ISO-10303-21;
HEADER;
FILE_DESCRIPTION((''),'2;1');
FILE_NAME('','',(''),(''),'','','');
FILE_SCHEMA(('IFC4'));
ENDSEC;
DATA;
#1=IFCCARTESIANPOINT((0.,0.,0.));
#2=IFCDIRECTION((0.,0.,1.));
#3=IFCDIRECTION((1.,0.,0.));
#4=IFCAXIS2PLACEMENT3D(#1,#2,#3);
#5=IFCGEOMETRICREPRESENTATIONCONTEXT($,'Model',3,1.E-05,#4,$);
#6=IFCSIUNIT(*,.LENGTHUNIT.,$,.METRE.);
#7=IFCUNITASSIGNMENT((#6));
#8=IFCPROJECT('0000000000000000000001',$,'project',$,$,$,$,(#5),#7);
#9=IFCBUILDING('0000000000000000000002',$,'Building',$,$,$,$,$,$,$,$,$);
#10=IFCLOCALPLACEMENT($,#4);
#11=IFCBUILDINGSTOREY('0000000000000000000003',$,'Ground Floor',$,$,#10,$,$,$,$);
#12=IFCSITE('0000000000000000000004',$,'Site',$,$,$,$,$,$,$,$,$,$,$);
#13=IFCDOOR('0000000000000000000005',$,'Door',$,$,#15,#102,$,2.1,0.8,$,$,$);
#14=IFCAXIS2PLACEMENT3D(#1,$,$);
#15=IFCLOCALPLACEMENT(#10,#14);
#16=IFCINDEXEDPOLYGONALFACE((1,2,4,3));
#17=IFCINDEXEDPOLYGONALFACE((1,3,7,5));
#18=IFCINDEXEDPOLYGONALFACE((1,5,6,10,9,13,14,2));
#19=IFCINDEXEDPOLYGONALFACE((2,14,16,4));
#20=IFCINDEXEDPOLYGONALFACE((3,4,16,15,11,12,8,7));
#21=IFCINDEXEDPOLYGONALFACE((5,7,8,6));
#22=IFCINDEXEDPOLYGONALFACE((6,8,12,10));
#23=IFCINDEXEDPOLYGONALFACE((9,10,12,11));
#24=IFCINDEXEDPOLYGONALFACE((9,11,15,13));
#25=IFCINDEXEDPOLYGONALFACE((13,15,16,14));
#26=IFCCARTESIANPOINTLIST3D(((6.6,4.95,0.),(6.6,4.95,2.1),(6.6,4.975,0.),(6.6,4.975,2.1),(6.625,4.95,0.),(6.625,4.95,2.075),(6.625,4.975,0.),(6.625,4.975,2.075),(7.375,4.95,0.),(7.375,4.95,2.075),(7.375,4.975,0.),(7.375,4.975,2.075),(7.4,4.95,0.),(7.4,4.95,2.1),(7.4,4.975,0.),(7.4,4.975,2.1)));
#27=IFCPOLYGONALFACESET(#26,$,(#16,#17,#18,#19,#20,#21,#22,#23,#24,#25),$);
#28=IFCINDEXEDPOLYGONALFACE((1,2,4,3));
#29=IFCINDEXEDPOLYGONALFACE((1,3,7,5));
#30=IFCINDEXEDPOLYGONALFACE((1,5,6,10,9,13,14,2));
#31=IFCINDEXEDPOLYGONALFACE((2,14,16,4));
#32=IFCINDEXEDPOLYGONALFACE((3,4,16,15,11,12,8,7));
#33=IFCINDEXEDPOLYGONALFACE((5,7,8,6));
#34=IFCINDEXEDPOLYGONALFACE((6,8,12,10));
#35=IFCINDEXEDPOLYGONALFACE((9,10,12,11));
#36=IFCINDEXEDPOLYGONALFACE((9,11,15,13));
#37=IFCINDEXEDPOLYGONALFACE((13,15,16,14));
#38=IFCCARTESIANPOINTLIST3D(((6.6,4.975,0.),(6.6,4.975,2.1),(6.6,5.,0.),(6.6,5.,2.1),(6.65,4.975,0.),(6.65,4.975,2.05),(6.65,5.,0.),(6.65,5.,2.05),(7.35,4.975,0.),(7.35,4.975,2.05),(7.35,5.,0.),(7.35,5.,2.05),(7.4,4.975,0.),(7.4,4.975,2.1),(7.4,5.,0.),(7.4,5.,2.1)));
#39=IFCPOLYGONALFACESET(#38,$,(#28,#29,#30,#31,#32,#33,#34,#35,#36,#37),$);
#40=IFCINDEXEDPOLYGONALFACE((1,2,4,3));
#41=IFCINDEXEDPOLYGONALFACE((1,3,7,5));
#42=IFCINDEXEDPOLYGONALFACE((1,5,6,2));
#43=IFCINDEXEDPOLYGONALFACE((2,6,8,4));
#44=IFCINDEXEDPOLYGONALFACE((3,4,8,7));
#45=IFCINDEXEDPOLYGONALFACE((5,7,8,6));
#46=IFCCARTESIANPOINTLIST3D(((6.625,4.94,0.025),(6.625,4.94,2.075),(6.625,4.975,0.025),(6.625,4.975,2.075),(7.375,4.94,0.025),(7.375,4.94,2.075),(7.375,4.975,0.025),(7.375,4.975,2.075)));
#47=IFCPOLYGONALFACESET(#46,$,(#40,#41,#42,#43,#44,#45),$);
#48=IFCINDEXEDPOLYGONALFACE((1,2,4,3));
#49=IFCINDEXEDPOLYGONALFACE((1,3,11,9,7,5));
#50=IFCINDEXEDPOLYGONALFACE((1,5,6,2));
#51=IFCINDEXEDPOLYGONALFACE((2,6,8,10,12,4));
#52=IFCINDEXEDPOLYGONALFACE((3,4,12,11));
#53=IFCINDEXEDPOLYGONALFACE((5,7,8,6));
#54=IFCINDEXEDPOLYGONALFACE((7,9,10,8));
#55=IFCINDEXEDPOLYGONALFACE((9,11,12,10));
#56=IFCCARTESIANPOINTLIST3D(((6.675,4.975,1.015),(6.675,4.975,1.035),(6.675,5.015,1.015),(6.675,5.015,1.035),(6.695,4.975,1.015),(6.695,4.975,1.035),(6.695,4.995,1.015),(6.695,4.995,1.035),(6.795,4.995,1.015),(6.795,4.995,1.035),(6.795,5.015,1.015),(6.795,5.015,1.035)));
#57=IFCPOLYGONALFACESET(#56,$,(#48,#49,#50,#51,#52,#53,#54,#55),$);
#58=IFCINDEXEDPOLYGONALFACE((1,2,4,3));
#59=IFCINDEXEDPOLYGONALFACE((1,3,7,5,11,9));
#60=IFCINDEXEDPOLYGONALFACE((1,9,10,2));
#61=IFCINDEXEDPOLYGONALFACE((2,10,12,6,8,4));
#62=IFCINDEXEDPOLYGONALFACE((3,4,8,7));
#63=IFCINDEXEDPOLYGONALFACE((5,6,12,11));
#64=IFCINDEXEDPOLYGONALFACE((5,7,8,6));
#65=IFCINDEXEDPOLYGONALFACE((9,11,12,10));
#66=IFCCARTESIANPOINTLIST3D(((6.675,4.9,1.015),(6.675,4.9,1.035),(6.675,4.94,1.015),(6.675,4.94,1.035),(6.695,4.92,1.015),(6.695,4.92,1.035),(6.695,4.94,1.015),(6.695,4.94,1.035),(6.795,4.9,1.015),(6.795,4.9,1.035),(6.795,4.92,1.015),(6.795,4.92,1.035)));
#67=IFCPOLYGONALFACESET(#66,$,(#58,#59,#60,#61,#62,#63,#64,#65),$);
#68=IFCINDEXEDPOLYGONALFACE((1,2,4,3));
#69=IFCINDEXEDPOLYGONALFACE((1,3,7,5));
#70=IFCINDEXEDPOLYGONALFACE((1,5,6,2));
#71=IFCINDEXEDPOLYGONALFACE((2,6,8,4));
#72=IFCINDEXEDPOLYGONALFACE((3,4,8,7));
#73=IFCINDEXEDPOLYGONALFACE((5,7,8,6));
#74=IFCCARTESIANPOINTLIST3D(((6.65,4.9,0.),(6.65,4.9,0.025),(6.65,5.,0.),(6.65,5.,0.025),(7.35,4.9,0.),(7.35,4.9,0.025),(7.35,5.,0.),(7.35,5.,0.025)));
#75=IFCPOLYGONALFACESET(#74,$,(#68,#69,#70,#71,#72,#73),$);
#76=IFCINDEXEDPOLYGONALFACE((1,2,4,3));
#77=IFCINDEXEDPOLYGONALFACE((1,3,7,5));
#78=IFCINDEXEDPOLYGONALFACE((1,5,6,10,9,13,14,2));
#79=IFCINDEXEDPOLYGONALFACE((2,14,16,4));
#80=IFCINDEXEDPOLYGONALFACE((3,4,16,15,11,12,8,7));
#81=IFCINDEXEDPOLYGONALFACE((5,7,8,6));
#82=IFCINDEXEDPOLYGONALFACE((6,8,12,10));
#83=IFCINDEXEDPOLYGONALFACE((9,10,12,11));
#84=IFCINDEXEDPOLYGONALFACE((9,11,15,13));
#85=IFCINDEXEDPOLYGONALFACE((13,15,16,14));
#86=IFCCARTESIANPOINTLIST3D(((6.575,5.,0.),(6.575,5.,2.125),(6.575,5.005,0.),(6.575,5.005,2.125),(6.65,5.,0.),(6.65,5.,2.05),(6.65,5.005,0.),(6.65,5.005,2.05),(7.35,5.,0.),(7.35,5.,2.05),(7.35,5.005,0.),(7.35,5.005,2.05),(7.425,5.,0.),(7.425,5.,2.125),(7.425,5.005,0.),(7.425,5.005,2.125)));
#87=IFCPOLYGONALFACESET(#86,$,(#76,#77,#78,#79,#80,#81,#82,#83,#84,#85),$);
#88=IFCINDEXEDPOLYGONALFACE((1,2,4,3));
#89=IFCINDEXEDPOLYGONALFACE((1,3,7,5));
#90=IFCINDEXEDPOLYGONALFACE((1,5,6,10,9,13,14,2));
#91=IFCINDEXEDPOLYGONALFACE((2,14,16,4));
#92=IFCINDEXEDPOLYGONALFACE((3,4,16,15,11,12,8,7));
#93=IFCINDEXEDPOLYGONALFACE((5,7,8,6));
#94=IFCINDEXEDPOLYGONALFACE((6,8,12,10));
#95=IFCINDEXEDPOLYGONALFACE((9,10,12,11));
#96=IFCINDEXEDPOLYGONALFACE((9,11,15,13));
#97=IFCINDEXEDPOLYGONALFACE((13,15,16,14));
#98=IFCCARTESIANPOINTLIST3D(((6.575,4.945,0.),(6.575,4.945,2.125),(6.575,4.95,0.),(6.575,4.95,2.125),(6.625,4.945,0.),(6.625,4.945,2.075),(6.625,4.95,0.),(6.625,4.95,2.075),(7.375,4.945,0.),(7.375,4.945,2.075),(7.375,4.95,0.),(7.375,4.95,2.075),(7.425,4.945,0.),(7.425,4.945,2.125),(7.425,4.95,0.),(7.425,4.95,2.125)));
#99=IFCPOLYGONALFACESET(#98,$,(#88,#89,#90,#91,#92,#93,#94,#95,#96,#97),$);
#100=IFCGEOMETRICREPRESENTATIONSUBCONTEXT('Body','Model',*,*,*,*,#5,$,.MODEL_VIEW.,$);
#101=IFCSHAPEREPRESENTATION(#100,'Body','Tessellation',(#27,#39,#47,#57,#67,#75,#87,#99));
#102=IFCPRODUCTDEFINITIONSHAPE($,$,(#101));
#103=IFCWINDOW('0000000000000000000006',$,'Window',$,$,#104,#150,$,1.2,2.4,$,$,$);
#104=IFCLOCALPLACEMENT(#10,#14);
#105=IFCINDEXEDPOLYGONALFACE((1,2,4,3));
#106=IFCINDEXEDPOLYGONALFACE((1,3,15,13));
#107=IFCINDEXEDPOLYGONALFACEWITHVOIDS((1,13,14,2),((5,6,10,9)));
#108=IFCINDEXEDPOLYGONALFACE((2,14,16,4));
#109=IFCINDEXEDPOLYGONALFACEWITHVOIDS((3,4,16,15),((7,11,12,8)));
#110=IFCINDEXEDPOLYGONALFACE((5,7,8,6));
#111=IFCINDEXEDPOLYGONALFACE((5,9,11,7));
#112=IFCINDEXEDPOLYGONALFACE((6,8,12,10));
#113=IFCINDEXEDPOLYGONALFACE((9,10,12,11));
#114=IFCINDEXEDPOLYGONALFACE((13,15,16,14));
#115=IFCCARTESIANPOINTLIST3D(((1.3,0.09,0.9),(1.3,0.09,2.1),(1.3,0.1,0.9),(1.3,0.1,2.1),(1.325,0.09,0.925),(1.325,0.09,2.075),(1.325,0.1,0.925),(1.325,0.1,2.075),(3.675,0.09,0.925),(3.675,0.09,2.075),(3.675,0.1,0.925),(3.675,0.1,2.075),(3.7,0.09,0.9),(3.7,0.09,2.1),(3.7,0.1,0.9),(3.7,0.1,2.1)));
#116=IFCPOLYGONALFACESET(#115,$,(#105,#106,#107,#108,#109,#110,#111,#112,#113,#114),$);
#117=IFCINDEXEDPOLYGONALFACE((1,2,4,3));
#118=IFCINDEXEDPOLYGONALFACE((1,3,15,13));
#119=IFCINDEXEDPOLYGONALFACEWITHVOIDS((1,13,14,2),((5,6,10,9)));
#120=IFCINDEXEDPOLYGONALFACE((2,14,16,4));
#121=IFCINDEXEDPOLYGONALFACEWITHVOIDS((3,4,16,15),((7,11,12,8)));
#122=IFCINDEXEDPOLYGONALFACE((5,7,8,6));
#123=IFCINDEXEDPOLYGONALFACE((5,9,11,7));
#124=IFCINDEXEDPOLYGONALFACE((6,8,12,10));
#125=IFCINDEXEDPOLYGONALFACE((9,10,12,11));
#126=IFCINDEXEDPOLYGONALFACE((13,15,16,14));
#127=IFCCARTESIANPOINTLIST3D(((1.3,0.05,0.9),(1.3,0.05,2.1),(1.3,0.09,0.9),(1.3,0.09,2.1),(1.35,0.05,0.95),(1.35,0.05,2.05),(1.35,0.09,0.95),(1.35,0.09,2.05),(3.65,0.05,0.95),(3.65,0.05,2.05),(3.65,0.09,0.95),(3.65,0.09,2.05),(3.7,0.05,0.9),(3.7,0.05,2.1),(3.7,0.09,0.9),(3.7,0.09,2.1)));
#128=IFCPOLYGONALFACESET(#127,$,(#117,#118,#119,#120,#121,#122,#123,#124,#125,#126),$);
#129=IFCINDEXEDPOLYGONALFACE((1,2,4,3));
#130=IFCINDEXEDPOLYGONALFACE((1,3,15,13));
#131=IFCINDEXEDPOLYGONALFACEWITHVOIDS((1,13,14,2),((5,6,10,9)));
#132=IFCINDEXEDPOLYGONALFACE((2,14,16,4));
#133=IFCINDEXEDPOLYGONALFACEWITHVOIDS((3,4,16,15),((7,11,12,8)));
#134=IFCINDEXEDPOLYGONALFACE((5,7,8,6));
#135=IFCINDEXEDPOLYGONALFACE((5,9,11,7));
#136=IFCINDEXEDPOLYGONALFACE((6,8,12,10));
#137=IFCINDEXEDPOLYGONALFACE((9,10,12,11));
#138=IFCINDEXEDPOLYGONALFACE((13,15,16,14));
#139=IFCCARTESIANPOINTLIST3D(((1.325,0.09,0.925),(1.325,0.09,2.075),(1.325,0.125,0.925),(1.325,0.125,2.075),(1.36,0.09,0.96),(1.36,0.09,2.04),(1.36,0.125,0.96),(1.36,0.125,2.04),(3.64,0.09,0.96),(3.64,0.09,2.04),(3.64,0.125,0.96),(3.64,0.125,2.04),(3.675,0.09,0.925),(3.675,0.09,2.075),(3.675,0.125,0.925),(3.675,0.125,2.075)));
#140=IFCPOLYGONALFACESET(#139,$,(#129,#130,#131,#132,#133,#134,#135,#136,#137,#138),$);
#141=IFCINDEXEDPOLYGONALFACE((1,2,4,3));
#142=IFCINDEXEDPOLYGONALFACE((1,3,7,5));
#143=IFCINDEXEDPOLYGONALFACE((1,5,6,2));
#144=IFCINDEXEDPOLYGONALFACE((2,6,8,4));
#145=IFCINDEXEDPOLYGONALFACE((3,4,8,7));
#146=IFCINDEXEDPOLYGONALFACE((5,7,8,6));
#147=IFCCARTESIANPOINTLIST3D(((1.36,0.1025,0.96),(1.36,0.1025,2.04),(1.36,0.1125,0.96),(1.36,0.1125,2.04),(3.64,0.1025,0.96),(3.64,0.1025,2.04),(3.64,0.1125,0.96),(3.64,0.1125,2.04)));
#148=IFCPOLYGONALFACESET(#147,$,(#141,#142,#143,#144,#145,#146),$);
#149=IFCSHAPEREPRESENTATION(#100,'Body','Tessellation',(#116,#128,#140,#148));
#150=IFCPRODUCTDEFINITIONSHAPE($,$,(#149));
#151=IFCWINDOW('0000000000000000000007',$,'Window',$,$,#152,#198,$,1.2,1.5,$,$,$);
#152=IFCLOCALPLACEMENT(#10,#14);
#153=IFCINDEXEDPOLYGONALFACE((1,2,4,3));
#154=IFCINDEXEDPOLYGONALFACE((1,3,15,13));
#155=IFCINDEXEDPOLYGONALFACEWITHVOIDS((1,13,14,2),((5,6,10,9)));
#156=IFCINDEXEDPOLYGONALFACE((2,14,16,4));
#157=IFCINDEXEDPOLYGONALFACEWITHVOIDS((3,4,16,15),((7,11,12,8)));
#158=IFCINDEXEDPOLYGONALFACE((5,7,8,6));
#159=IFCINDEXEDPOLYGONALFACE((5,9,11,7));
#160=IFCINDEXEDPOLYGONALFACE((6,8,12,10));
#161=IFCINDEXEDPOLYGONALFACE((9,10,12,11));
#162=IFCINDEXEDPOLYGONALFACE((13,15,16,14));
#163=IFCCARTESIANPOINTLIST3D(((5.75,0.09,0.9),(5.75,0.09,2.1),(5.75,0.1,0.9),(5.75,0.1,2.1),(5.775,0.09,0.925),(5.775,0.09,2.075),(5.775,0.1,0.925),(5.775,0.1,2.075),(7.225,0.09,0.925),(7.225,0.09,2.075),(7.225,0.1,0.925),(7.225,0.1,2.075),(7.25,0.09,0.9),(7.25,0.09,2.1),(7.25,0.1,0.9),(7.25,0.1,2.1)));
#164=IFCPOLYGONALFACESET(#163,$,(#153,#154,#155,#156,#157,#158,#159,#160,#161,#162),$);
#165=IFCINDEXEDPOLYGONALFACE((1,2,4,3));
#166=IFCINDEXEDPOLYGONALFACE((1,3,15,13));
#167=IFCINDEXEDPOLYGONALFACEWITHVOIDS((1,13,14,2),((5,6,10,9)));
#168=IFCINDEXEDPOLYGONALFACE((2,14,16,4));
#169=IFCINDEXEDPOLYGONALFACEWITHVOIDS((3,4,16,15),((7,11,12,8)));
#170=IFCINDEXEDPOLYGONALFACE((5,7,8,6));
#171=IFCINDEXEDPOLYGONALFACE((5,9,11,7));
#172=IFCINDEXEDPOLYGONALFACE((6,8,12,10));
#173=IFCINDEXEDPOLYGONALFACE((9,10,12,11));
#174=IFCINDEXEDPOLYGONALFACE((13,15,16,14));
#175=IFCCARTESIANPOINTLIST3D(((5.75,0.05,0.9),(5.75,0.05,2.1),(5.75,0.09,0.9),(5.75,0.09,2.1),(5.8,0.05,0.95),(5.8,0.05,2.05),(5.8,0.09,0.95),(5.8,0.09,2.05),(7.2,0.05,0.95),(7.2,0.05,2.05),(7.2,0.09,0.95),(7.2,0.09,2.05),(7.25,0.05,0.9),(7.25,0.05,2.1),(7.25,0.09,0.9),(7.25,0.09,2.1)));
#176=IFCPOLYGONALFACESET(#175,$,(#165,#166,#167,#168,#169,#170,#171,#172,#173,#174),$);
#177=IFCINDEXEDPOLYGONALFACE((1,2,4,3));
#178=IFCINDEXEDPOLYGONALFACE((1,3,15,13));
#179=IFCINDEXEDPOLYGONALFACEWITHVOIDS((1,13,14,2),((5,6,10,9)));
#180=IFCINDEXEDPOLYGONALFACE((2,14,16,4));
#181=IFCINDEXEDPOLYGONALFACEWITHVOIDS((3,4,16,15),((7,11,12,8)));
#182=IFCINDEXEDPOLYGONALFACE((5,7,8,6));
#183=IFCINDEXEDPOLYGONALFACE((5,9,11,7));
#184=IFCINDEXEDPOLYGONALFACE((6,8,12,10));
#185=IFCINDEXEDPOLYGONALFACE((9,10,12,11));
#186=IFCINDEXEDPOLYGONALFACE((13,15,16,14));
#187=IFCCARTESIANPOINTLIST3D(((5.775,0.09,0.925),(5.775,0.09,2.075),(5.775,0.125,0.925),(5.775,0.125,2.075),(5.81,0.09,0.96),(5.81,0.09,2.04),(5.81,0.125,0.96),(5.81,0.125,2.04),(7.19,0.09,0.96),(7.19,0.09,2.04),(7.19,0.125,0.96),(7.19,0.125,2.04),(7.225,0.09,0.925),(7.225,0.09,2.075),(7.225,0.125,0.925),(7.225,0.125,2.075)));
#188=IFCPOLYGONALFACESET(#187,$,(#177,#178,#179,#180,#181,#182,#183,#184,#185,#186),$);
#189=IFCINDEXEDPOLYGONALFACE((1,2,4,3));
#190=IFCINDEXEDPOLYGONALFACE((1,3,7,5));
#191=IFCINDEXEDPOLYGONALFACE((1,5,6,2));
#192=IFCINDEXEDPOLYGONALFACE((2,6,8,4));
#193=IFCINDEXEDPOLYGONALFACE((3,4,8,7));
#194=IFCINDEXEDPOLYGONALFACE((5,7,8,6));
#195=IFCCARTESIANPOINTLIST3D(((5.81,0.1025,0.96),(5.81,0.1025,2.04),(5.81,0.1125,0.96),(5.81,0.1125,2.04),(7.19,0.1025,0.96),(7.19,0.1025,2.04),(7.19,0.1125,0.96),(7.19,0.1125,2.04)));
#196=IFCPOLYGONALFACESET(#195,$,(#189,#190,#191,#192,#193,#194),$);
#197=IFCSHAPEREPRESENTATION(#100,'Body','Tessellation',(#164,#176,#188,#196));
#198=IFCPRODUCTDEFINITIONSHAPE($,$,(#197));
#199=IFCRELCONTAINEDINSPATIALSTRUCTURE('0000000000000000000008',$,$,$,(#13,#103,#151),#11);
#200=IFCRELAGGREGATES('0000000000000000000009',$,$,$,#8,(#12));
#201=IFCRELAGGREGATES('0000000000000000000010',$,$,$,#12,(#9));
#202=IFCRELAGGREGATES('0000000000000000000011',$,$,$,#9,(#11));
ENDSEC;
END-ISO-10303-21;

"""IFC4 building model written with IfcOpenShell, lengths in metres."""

from ifc_helpers import new_model, si_unit, frame, origin_with_axes, place, context, subcontext, project, spatial, line, indexed_curve, outline, extrude, element, save


model = new_model("IFC4")

# Units and contexts
model_context = context("Model", 3, precision=1e-05, world=origin_with_axes())
body_context = subcontext(model_context, "Body", "Model", "MODEL_VIEW")
ifc_project = project(units=[si_unit("LENGTHUNIT", "METRE")], contexts=[model_context])

# Site, building, storey
site = spatial("IfcSite", under=ifc_project, Name="Site")
building = spatial("IfcBuilding", under=site, Name="Building")
storey_placement = place(None, origin_with_axes())
storey = spatial("IfcBuildingStorey", under=building, at=storey_placement, Name="Ground Floor")

# Door
door_1_placement = place(storey_placement, frame((7.4, 5.0, 0.0), z_axis=(0.0, 0.0, 1.0), x_axis=(-1.0, 0.0, 0.0)))
element("IfcDoor", 1, at=door_1_placement, inside=storey, Name="Door", OverallHeight=2.1, OverallWidth=0.8, context=body_context, shape_type="SweptSolid", body=[
    extrude(outline(indexed_curve([(0.0, 0.0), (0.0, 2.1), (0.8, 2.1), (0.8, 0.0), (0.775, 0.0), (0.775, 2.075), (0.025, 2.075), (0.025, 0.0)], segments=[line(1, 2, 3, 4, 5, 6, 7, 8, 1)])), frame((0.0, 0.025, 0.0), z_axis=(0.0, -1.0, 0.0), x_axis=(1.0, 0.0, 0.0)), (0.0, 0.0, -1.0), 0.025),
    extrude(outline(indexed_curve([(0.0, 0.0), (0.0, 2.1), (0.8, 2.1), (0.8, 0.0), (0.75, 0.0), (0.75, 2.05), (0.05, 2.05), (0.05, 0.0)], segments=[line(1, 2, 3, 4, 5, 6, 7, 8, 1)])), frame((0.0, 0.0, 0.0), z_axis=(0.0, -1.0, 0.0), x_axis=(1.0, 0.0, 0.0)), (0.0, 0.0, -1.0), 0.025),
    extrude(outline(indexed_curve([(0.0, 0.0), (0.75, 0.0), (0.75, 0.035), (0.0, 0.035)], segments=[line(1, 2, 3, 4, 1)])), frame((0.025, 0.025, 0.025), z_axis=(0.0, 0.0, 1.0), x_axis=(1.0, 0.0, 0.0)), (0.0, 0.0, 1.0), 2.05),
    extrude(outline(indexed_curve([(0.0, 0.0), (0.0, -0.04), (-0.12, -0.04), (-0.12, -0.02), (-0.02, -0.02), (-0.02, 0.0)], segments=[line(1, 2, 3, 4, 5, 6, 1)])), frame((0.725, 0.025, 1.015), z_axis=(0.0, 0.0, 1.0), x_axis=(1.0, 0.0, 0.0)), (0.0, 0.0, 1.0), 0.02),
    extrude(outline(indexed_curve([(0.0, 0.0), (0.0, 0.04), (-0.12, 0.04), (-0.12, 0.02), (-0.02, 0.02), (-0.02, 0.0)], segments=[line(1, 2, 3, 4, 5, 6, 1)])), frame((0.725, 0.06, 1.015), z_axis=(0.0, 0.0, 1.0), x_axis=(1.0, 0.0, 0.0)), (0.0, 0.0, 1.0), 0.02),
    extrude(outline(indexed_curve([(0.0, 0.0), (0.7, 0.0), (0.7, 0.1), (0.0, 0.1)], segments=[line(1, 2, 3, 4, 1)])), frame((0.05, 0.0, 0.0), z_axis=(0.0, 0.0, 1.0), x_axis=(1.0, 0.0, 0.0)), (0.0, 0.0, 1.0), 0.025),
    extrude(outline(indexed_curve([(0.0, 0.0), (0.0, 2.125), (0.85, 2.125), (0.85, 0.0), (0.775, 0.0), (0.775, 2.05), (0.075, 2.05), (0.075, 0.0)], segments=[line(1, 2, 3, 4, 5, 6, 7, 8, 1)])), frame((-0.025, -0.005, 0.0), z_axis=(0.0, -1.0, 0.0), x_axis=(1.0, 0.0, 0.0)), (0.0, 0.0, -1.0), 0.005),
    extrude(outline(indexed_curve([(0.0, 0.0), (0.0, 2.125), (0.85, 2.125), (0.85, 0.0), (0.8, 0.0), (0.8, 2.075), (0.05, 2.075), (0.05, 0.0)], segments=[line(1, 2, 3, 4, 5, 6, 7, 8, 1)])), frame((-0.025, 0.05, 0.0), z_axis=(0.0, -1.0, 0.0), x_axis=(1.0, 0.0, 0.0)), (0.0, 0.0, -1.0), 0.005),
])

# Windows
window_1_placement = place(storey_placement, frame((1.3, 0.0, 0.9), z_axis=(0.0, 0.0, 1.0), x_axis=(1.0, 0.0, 0.0)))
element("IfcWindow", 2, at=window_1_placement, inside=storey, Name="Window", OverallHeight=1.2, OverallWidth=2.4, context=body_context, shape_type="SweptSolid", body=[
    extrude(outline(indexed_curve([(0.0, 0.0), (2.4, 0.0), (2.4, 1.2), (0.0, 1.2)], segments=[line(1, 2, 3, 4, 1)]), holes=[indexed_curve([(0.025, 0.025), (2.375, 0.025), (2.375, 1.175), (0.025, 1.175)], segments=[line(1, 2, 3, 4, 1)])]), frame((0.0, 0.09, 0.0), z_axis=(0.0, -1.0, 0.0), x_axis=(1.0, 0.0, 0.0)), (0.0, 0.0, -1.0), 0.01),
    extrude(outline(indexed_curve([(0.0, 0.0), (2.4, 0.0), (2.4, 1.2), (0.0, 1.2)], segments=[line(1, 2, 3, 4, 1)]), holes=[indexed_curve([(0.05, 0.05), (2.35, 0.05), (2.35, 1.15), (0.05, 1.15)], segments=[line(1, 2, 3, 4, 1)])]), frame((0.0, 0.05, 0.0), z_axis=(0.0, -1.0, 0.0), x_axis=(1.0, 0.0, 0.0)), (0.0, 0.0, -1.0), 0.04),
    extrude(outline(indexed_curve([(0.0, 0.0), (2.35, 0.0), (2.35, 1.15), (0.0, 1.15)], segments=[line(1, 2, 3, 4, 1)]), holes=[indexed_curve([(0.035, 0.035), (2.315, 0.035), (2.315, 1.115), (0.035, 1.115)], segments=[line(1, 2, 3, 4, 1)])]), frame((0.025, 0.09, 0.025), z_axis=(0.0, -1.0, 0.0), x_axis=(1.0, 0.0, 0.0)), (0.0, 0.0, -1.0), 0.035),
    extrude(outline(indexed_curve([(0.035, 0.035), (2.315, 0.035), (2.315, 1.115), (0.035, 1.115)], segments=[line(1, 2, 3, 4, 1)])), frame((0.025, 0.1025, 0.025), z_axis=(0.0, -1.0, 0.0), x_axis=(1.0, 0.0, 0.0)), (0.0, 0.0, -1.0), 0.01),
])
for number, where, z_axis, x_axis, name in (
    (3, (5.75, 0.0, 0.9), (0.0, 0.0, 1.0), (1.0, 0.0, 0.0), "Window"),
):
    element("IfcWindow", number, at=place(storey_placement, frame(where, z_axis=z_axis, x_axis=x_axis)), inside=storey, Name=name, OverallHeight=1.2, OverallWidth=1.5, context=body_context, shape_type="SweptSolid", body=[
        extrude(outline(indexed_curve([(0.0, 0.0), (1.5, 0.0), (1.5, 1.2), (0.0, 1.2)], segments=[line(1, 2, 3, 4, 1)]), holes=[indexed_curve([(0.025, 0.025), (1.475, 0.025), (1.475, 1.175), (0.025, 1.175)], segments=[line(1, 2, 3, 4, 1)])]), frame((0.0, 0.09, 0.0), z_axis=(0.0, -1.0, 0.0), x_axis=(1.0, 0.0, 0.0)), (0.0, 0.0, -1.0), 0.01),
        extrude(outline(indexed_curve([(0.0, 0.0), (1.5, 0.0), (1.5, 1.2), (0.0, 1.2)], segments=[line(1, 2, 3, 4, 1)]), holes=[indexed_curve([(0.05, 0.05), (1.45, 0.05), (1.45, 1.15), (0.05, 1.15)], segments=[line(1, 2, 3, 4, 1)])]), frame((0.0, 0.05, 0.0), z_axis=(0.0, -1.0, 0.0), x_axis=(1.0, 0.0, 0.0)), (0.0, 0.0, -1.0), 0.04),
        extrude(outline(indexed_curve([(0.0, 0.0), (1.45, 0.0), (1.45, 1.15), (0.0, 1.15)], segments=[line(1, 2, 3, 4, 1)]), holes=[indexed_curve([(0.035, 0.035), (1.415, 0.035), (1.415, 1.115), (0.035, 1.115)], segments=[line(1, 2, 3, 4, 1)])]), frame((0.025, 0.09, 0.025), z_axis=(0.0, -1.0, 0.0), x_axis=(1.0, 0.0, 0.0)), (0.0, 0.0, -1.0), 0.035),
        extrude(outline(indexed_curve([(0.035, 0.035), (1.415, 0.035), (1.415, 1.115), (0.035, 1.115)], segments=[line(1, 2, 3, 4, 1)])), frame((0.025, 0.1025, 0.025), z_axis=(0.0, -1.0, 0.0), x_axis=(1.0, 0.0, 0.0)), (0.0, 0.0, -1.0), 0.01),
    ])

save(model, "model.ifc")
